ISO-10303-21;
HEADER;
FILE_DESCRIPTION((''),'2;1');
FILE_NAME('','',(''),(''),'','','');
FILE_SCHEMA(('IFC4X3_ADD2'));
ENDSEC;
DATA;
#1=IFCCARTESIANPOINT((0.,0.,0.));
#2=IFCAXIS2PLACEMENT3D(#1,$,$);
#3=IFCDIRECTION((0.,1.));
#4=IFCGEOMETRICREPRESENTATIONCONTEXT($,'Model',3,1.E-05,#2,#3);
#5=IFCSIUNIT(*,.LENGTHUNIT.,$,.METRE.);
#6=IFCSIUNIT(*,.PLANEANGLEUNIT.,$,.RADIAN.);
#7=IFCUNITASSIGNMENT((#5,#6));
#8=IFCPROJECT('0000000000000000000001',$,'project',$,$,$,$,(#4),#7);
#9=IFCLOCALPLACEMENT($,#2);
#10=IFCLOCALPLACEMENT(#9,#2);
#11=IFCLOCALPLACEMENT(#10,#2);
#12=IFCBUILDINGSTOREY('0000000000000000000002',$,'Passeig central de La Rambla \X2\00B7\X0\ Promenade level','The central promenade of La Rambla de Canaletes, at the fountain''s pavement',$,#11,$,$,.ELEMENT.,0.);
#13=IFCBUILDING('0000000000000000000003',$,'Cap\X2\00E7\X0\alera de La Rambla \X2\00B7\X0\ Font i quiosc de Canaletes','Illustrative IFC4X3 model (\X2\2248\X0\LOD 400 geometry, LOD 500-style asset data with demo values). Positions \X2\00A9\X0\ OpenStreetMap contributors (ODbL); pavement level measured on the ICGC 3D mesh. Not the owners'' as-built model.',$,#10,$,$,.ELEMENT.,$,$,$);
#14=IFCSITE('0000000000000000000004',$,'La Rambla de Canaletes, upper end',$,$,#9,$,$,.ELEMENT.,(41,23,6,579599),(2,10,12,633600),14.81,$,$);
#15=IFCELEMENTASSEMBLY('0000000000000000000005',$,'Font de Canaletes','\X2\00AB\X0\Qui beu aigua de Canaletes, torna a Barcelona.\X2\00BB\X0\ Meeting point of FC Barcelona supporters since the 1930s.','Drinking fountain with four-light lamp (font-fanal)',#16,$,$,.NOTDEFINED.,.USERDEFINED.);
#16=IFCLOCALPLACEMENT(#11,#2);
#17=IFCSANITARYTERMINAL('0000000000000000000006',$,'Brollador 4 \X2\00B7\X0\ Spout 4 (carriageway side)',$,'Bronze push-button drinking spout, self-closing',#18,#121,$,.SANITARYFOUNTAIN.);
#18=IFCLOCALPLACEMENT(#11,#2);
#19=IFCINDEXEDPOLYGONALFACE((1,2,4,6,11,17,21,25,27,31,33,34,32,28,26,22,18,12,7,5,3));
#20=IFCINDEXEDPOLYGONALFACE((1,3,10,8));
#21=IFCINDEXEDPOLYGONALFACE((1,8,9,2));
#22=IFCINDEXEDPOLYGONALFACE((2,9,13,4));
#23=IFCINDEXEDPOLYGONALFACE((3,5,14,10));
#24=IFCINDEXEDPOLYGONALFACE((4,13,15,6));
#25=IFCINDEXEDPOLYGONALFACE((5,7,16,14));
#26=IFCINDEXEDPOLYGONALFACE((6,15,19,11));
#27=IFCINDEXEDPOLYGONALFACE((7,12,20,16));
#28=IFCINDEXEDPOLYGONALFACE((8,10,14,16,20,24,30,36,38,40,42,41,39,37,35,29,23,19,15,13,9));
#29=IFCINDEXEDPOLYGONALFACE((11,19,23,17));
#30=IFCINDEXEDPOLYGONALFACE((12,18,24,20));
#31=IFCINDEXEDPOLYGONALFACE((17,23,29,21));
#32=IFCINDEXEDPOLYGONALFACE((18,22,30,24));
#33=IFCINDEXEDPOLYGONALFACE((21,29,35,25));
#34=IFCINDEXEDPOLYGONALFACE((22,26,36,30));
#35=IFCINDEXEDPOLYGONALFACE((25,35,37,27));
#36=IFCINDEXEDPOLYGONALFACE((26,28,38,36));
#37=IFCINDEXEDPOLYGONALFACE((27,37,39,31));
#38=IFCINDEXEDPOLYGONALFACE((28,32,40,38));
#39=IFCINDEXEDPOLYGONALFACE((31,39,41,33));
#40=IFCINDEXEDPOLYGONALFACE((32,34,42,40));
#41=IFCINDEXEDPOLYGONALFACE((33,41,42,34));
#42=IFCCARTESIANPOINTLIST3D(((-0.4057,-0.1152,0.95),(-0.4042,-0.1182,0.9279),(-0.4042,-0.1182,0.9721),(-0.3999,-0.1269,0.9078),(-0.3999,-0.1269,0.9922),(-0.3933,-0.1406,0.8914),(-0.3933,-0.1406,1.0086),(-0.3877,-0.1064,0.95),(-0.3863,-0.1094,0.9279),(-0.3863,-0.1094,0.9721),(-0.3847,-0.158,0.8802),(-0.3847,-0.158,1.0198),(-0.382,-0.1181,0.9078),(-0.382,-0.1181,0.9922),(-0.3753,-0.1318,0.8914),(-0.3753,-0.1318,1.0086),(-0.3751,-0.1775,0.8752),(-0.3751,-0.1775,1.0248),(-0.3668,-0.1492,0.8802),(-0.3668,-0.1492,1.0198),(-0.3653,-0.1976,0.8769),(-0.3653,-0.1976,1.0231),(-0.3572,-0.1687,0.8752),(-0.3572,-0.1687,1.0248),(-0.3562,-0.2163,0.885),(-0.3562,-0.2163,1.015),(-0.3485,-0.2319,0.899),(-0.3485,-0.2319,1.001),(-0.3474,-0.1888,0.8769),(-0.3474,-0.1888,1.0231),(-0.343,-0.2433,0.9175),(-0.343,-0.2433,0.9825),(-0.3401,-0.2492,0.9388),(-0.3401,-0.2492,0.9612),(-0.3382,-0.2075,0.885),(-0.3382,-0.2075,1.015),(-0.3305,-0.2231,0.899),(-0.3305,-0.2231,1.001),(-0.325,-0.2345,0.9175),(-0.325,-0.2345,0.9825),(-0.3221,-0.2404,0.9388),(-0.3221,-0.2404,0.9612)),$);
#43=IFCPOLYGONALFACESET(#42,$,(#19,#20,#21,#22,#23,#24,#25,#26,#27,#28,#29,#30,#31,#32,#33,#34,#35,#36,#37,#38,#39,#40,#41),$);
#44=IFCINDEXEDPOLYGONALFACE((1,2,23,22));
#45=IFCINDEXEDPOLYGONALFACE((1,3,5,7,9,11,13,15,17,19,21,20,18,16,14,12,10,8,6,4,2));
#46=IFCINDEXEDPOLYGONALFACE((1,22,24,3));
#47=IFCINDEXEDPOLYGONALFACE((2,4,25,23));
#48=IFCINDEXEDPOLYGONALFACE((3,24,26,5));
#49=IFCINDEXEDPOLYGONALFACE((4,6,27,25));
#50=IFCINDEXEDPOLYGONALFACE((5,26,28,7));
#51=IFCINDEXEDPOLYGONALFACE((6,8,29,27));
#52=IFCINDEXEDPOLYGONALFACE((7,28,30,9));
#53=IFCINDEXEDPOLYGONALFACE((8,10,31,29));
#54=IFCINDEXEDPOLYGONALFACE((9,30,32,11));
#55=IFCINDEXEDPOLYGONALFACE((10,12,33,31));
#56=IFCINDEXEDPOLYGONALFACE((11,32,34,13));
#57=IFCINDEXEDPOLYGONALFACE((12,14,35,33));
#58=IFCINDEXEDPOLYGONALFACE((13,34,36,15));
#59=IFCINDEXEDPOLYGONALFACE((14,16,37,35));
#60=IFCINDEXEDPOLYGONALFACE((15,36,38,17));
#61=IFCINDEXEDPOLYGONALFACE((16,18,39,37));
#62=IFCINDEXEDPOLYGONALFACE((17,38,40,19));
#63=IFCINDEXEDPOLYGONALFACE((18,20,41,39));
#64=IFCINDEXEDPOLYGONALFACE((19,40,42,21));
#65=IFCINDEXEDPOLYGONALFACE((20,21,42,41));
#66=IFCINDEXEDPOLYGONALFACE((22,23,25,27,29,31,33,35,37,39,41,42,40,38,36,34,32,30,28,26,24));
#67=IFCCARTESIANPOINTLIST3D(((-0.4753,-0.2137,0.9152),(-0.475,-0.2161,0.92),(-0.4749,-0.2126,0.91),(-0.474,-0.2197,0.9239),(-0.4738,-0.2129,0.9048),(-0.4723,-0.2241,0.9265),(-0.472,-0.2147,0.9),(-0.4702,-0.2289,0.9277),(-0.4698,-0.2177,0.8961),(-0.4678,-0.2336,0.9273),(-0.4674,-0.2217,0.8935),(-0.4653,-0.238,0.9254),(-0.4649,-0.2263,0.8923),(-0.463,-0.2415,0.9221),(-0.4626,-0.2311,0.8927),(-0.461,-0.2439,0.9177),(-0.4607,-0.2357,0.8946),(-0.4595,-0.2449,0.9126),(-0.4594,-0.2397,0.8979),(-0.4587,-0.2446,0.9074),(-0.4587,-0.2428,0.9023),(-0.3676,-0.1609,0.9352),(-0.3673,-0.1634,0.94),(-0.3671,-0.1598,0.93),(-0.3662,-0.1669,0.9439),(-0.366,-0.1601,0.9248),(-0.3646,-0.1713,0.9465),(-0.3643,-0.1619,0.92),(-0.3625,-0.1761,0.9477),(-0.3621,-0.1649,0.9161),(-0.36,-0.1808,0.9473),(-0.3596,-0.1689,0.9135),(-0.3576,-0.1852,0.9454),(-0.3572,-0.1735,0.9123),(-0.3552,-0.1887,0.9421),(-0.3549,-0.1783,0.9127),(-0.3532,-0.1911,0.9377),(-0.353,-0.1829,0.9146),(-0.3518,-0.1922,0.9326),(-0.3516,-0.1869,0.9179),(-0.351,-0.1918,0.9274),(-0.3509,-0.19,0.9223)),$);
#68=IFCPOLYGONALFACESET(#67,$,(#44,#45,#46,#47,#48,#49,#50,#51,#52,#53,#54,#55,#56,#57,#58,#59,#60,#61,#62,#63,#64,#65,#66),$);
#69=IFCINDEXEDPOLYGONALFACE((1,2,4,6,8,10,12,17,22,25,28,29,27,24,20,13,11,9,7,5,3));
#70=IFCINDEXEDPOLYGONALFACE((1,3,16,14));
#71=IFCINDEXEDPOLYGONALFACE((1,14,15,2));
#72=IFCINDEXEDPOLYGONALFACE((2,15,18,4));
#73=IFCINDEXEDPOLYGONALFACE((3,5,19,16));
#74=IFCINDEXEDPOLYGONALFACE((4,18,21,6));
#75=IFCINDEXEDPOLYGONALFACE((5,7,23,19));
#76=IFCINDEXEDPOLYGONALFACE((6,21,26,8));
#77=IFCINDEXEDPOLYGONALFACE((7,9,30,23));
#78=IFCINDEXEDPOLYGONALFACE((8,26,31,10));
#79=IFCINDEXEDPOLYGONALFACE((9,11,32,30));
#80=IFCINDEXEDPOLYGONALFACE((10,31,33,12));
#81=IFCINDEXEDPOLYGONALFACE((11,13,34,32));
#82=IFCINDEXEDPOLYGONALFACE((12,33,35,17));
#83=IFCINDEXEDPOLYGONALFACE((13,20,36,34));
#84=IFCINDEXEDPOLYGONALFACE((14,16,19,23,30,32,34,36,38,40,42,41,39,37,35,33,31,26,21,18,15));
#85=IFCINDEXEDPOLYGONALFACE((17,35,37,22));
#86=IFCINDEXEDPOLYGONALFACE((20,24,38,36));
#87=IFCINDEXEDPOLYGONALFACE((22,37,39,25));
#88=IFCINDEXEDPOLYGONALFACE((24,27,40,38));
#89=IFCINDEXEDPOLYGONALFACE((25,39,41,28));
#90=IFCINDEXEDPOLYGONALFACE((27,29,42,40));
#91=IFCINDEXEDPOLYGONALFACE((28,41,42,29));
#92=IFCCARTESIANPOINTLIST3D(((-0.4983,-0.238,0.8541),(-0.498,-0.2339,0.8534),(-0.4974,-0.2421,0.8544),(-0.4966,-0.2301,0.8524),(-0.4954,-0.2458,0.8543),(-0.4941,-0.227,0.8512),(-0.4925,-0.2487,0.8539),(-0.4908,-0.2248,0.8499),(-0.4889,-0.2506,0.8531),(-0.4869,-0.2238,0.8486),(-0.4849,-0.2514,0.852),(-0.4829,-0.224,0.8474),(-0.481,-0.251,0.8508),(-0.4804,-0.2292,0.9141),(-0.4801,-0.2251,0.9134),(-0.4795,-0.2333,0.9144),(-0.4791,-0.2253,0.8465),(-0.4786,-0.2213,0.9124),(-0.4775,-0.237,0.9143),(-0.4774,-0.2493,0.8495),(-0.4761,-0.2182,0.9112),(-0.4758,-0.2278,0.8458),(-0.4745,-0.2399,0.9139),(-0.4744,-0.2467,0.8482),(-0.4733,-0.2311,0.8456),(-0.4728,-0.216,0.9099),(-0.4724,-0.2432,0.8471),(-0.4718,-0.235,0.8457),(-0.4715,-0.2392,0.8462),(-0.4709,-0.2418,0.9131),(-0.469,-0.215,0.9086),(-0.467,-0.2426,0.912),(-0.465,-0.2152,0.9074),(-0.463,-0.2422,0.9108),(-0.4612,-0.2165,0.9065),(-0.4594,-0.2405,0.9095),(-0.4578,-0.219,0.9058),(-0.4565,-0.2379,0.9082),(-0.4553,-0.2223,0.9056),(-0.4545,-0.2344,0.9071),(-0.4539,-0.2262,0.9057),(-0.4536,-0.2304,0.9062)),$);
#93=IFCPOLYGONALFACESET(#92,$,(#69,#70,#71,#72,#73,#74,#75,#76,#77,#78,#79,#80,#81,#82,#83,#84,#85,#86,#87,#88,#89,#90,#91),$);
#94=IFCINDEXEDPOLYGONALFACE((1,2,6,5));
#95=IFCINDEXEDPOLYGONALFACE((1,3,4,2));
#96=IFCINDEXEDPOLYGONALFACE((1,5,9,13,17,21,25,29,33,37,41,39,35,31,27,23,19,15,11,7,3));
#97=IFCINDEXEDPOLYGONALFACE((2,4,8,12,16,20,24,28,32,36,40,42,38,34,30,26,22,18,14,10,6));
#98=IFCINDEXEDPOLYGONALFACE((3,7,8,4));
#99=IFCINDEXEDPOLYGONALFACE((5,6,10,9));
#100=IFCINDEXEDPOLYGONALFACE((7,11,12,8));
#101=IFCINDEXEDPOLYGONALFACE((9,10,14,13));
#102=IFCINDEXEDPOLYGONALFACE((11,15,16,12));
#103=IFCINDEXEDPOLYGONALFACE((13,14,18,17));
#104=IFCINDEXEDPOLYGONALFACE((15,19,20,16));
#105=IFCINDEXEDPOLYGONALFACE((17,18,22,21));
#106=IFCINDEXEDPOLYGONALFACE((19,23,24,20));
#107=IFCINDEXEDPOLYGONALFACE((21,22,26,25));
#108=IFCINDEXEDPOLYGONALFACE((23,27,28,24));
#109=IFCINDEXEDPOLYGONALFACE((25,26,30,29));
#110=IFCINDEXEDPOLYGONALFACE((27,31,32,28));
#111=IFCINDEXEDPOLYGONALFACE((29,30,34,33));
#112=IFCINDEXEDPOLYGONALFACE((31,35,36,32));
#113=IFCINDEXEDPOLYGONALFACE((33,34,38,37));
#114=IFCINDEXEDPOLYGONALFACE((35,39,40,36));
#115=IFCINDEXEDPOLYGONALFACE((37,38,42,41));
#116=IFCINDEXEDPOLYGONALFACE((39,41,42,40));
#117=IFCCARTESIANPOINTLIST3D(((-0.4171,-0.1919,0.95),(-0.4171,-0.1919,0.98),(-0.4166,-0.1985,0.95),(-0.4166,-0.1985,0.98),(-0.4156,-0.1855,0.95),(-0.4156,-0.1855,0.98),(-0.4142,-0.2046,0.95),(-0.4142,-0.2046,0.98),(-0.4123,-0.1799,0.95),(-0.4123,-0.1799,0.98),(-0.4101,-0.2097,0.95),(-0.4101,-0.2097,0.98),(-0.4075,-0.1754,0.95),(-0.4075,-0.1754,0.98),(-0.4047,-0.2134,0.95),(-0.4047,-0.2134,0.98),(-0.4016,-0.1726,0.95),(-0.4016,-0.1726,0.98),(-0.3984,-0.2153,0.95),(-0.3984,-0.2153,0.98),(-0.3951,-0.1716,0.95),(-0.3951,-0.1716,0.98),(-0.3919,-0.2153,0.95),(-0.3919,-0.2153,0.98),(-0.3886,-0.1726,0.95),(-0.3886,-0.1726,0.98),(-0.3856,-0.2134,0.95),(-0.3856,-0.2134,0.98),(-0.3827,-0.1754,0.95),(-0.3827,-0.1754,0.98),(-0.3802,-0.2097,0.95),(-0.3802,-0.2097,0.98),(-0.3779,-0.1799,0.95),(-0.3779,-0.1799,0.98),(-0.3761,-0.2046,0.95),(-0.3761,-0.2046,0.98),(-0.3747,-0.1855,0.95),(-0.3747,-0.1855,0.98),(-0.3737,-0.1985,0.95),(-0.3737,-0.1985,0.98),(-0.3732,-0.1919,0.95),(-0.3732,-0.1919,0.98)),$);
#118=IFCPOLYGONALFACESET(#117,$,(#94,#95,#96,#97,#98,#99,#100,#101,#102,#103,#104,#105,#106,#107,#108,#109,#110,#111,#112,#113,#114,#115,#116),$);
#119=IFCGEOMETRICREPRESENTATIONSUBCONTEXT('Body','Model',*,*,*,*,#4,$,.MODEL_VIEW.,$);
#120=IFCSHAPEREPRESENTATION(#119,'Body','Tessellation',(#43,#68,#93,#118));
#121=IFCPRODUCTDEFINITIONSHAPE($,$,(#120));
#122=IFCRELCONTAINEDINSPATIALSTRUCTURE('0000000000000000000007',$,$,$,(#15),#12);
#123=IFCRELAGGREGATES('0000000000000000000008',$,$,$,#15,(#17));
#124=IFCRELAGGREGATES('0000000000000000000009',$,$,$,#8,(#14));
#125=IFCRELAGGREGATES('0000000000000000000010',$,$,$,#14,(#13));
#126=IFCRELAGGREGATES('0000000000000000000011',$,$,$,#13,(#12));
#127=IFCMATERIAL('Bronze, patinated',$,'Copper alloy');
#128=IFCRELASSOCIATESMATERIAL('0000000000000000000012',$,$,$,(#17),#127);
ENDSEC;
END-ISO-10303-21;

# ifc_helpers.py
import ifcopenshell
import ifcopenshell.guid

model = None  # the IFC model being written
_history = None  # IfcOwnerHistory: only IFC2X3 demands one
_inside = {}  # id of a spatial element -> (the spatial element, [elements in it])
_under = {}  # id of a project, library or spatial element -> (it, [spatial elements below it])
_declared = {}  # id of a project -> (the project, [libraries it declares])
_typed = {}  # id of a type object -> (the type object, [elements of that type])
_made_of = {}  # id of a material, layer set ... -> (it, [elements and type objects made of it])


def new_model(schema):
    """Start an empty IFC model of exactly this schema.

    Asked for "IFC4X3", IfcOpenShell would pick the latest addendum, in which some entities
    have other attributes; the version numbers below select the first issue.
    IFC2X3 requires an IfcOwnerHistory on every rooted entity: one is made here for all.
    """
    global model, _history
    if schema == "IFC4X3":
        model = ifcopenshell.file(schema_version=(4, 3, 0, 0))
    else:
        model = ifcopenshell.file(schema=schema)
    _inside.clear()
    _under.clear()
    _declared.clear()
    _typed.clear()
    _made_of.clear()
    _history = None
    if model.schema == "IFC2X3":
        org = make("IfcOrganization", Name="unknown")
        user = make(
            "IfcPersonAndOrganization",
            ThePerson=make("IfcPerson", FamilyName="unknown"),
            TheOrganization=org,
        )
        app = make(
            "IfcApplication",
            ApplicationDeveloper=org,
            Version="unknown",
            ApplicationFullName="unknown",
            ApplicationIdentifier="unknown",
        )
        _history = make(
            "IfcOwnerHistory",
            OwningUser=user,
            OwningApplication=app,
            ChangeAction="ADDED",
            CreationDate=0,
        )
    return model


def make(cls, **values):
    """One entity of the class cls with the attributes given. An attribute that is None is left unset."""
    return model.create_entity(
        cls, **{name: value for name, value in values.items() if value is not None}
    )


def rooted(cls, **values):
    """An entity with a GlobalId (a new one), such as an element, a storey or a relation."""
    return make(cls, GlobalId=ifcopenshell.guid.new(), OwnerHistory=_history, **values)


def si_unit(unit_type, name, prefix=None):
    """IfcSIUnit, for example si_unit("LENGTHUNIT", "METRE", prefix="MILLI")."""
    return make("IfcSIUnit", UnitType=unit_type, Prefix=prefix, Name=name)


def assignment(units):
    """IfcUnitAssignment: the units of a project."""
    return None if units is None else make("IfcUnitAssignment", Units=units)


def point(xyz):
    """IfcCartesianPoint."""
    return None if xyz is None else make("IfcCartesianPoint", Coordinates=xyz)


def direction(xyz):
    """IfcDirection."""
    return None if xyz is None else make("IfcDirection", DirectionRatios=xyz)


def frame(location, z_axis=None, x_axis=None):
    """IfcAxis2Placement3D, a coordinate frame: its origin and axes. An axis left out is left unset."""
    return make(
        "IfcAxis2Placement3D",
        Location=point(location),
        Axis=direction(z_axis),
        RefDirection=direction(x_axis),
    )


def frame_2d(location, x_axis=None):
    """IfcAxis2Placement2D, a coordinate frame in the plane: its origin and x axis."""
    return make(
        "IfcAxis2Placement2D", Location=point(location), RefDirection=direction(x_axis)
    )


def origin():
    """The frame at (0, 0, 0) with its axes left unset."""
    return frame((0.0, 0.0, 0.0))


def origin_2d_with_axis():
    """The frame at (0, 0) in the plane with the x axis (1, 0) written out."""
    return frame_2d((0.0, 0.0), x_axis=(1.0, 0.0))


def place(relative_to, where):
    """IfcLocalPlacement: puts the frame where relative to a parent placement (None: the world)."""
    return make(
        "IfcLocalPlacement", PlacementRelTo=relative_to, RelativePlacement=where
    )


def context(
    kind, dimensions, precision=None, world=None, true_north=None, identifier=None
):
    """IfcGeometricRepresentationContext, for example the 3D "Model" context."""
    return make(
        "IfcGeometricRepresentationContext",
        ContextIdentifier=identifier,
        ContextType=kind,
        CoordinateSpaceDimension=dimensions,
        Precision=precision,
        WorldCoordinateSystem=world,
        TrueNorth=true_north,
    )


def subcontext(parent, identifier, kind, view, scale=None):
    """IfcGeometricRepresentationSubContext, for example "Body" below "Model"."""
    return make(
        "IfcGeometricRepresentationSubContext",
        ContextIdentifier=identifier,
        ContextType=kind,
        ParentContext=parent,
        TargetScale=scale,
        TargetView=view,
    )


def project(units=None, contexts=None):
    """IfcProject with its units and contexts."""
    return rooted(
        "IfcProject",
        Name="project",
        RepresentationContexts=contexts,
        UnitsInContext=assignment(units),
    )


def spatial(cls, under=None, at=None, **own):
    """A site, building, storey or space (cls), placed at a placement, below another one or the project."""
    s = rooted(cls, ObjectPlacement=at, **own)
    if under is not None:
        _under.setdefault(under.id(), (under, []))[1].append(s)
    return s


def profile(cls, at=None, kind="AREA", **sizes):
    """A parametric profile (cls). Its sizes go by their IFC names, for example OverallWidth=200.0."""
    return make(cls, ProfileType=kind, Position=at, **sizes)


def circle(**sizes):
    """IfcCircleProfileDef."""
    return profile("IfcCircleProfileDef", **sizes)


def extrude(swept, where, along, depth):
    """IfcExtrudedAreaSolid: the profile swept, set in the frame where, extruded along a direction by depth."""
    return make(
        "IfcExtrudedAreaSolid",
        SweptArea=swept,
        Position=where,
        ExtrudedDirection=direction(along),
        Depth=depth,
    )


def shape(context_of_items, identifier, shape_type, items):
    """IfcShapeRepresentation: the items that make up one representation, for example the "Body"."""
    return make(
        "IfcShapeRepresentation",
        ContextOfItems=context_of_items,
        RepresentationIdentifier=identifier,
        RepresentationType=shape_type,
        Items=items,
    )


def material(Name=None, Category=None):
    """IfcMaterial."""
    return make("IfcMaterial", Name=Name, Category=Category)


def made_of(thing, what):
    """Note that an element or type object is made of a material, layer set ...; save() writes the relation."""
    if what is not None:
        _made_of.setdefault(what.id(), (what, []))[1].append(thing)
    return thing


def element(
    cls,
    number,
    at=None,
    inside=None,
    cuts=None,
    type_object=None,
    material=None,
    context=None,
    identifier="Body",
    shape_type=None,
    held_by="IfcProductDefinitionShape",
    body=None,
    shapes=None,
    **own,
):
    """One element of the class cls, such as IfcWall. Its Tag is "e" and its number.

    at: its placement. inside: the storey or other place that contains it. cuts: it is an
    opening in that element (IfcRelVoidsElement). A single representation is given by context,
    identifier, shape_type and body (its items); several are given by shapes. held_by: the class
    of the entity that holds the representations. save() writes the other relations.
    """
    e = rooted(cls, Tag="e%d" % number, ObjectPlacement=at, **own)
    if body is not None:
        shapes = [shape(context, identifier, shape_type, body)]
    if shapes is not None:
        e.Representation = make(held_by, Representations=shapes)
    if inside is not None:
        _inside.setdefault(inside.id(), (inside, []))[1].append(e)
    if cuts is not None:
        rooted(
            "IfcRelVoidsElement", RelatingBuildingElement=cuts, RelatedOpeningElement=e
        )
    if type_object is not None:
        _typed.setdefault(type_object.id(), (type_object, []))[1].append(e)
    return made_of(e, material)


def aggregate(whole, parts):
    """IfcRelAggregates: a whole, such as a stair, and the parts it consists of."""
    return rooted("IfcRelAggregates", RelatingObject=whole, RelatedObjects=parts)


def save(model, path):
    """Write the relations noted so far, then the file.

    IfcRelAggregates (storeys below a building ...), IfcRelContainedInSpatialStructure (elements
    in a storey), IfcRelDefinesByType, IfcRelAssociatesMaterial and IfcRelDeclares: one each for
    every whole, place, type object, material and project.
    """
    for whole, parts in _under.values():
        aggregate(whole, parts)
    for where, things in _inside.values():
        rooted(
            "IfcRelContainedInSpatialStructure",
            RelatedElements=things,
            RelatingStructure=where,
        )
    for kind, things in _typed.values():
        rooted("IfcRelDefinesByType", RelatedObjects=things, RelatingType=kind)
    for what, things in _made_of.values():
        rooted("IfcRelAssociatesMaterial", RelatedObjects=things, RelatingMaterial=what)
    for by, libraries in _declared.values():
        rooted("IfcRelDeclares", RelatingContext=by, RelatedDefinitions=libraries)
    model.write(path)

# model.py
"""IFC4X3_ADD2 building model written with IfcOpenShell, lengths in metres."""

from ifc_helpers import new_model, si_unit, direction, frame, origin, origin_2d_with_axis, place, context, subcontext, project, spatial, circle, extrude, material, element, aggregate, save


model = new_model("IFC4X3_ADD2")

# Units and contexts
model_context = context("Model", 3, precision=1e-05, world=origin(), true_north=direction((0.0, 1.0)))
body_context = subcontext(model_context, "Body", "Model", "MODEL_VIEW")
ifc_project = project(units=[si_unit("LENGTHUNIT", "METRE"), si_unit("PLANEANGLEUNIT", "RADIAN")], contexts=[model_context])

# Site, building, storey
site_placement = place(None, origin())
site = spatial("IfcSite", under=ifc_project, at=site_placement, Name="La Rambla de Canaletes, upper end", CompositionType="ELEMENT", RefLatitude=(41, 23, 6, 579599), RefLongitude=(2, 10, 12, 633600), RefElevation=14.81)
building_placement = place(site_placement, origin())
building = spatial("IfcBuilding", under=site, at=building_placement, Name="Capçalera de La Rambla · Font i quiosc de Canaletes", Description="Illustrative IFC4X3 model (≈LOD 400 geometry, LOD 500-style asset data with demo values). Positions © OpenStreetMap contributors (ODbL); pavement level measured on the ICGC 3D mesh. Not the owners' as-built model.", CompositionType="ELEMENT")
storey_placement = place(building_placement, origin())
storey = spatial("IfcBuildingStorey", under=building, at=storey_placement, Name="Passeig central de La Rambla · Promenade level", Description="The central promenade of La Rambla de Canaletes, at the fountain's pavement", CompositionType="ELEMENT", Elevation=0.0)

# Element assembly, sanitary terminal
assembly_1_placement = place(building_placement, origin())
assembly_1 = element("IfcElementAssembly", 1, at=assembly_1_placement, inside=storey, Name="Font de Canaletes", Description="«Qui beu aigua de Canaletes, torna a Barcelona.» Meeting point of FC Barcelona supporters since the 1930s.", ObjectType="Drinking fountain with four-light lamp (font-fanal)", AssemblyPlace="NOTDEFINED", PredefinedType="USERDEFINED")
ifc_material_1 = material(Name="Bronze, patinated", Category="Copper alloy")
sanitary_terminal_1_placement = place(building_placement, origin())
sanitary_terminal_1 = element("IfcSanitaryTerminal", 2, at=sanitary_terminal_1_placement, material=ifc_material_1, Name="Brollador 4 · Spout 4 (carriageway side)", ObjectType="Bronze push-button drinking spout, self-closing", PredefinedType="SANITARYFOUNTAIN", context=body_context, shape_type="SweptSolid", body=[
    extrude(circle(Radius=0.075, at=origin_2d_with_axis()), frame((-0.3547, -0.1738, 0.95), z_axis=(-0.898028, -0.439939, 0.0), x_axis=(-0.439939, 0.898028, 0.0)), (0.0, 0.0, 1.0), 0.02),
    extrude(circle(Radius=0.018, at=origin_2d_with_axis()), frame((-0.3592, -0.176, 0.93), z_axis=(-0.885809, -0.433953, -0.164399), x_axis=(-0.439939, 0.898028, 0.0)), (0.0, 0.0, 1.0), 0.1217),
    extrude(circle(Radius=0.014, at=origin_2d_with_axis()), frame((-0.467, -0.2288, 0.91), z_axis=(-0.283981, -0.139121, -0.948683), x_axis=(0.0, -0.989418, 0.145095)), (0.0, 0.0, 1.0), 0.0632),
    extrude(circle(Radius=0.022, at=origin_2d_with_axis()), frame((-0.3951, -0.1936, 0.95), z_axis=(0.0, 0.0, 1.0), x_axis=(0.0, 1.0, 0.0)), (0.0, 0.0, 1.0), 0.03),
])
aggregate(assembly_1, [sanitary_terminal_1])

save(model, "model.ifc")
